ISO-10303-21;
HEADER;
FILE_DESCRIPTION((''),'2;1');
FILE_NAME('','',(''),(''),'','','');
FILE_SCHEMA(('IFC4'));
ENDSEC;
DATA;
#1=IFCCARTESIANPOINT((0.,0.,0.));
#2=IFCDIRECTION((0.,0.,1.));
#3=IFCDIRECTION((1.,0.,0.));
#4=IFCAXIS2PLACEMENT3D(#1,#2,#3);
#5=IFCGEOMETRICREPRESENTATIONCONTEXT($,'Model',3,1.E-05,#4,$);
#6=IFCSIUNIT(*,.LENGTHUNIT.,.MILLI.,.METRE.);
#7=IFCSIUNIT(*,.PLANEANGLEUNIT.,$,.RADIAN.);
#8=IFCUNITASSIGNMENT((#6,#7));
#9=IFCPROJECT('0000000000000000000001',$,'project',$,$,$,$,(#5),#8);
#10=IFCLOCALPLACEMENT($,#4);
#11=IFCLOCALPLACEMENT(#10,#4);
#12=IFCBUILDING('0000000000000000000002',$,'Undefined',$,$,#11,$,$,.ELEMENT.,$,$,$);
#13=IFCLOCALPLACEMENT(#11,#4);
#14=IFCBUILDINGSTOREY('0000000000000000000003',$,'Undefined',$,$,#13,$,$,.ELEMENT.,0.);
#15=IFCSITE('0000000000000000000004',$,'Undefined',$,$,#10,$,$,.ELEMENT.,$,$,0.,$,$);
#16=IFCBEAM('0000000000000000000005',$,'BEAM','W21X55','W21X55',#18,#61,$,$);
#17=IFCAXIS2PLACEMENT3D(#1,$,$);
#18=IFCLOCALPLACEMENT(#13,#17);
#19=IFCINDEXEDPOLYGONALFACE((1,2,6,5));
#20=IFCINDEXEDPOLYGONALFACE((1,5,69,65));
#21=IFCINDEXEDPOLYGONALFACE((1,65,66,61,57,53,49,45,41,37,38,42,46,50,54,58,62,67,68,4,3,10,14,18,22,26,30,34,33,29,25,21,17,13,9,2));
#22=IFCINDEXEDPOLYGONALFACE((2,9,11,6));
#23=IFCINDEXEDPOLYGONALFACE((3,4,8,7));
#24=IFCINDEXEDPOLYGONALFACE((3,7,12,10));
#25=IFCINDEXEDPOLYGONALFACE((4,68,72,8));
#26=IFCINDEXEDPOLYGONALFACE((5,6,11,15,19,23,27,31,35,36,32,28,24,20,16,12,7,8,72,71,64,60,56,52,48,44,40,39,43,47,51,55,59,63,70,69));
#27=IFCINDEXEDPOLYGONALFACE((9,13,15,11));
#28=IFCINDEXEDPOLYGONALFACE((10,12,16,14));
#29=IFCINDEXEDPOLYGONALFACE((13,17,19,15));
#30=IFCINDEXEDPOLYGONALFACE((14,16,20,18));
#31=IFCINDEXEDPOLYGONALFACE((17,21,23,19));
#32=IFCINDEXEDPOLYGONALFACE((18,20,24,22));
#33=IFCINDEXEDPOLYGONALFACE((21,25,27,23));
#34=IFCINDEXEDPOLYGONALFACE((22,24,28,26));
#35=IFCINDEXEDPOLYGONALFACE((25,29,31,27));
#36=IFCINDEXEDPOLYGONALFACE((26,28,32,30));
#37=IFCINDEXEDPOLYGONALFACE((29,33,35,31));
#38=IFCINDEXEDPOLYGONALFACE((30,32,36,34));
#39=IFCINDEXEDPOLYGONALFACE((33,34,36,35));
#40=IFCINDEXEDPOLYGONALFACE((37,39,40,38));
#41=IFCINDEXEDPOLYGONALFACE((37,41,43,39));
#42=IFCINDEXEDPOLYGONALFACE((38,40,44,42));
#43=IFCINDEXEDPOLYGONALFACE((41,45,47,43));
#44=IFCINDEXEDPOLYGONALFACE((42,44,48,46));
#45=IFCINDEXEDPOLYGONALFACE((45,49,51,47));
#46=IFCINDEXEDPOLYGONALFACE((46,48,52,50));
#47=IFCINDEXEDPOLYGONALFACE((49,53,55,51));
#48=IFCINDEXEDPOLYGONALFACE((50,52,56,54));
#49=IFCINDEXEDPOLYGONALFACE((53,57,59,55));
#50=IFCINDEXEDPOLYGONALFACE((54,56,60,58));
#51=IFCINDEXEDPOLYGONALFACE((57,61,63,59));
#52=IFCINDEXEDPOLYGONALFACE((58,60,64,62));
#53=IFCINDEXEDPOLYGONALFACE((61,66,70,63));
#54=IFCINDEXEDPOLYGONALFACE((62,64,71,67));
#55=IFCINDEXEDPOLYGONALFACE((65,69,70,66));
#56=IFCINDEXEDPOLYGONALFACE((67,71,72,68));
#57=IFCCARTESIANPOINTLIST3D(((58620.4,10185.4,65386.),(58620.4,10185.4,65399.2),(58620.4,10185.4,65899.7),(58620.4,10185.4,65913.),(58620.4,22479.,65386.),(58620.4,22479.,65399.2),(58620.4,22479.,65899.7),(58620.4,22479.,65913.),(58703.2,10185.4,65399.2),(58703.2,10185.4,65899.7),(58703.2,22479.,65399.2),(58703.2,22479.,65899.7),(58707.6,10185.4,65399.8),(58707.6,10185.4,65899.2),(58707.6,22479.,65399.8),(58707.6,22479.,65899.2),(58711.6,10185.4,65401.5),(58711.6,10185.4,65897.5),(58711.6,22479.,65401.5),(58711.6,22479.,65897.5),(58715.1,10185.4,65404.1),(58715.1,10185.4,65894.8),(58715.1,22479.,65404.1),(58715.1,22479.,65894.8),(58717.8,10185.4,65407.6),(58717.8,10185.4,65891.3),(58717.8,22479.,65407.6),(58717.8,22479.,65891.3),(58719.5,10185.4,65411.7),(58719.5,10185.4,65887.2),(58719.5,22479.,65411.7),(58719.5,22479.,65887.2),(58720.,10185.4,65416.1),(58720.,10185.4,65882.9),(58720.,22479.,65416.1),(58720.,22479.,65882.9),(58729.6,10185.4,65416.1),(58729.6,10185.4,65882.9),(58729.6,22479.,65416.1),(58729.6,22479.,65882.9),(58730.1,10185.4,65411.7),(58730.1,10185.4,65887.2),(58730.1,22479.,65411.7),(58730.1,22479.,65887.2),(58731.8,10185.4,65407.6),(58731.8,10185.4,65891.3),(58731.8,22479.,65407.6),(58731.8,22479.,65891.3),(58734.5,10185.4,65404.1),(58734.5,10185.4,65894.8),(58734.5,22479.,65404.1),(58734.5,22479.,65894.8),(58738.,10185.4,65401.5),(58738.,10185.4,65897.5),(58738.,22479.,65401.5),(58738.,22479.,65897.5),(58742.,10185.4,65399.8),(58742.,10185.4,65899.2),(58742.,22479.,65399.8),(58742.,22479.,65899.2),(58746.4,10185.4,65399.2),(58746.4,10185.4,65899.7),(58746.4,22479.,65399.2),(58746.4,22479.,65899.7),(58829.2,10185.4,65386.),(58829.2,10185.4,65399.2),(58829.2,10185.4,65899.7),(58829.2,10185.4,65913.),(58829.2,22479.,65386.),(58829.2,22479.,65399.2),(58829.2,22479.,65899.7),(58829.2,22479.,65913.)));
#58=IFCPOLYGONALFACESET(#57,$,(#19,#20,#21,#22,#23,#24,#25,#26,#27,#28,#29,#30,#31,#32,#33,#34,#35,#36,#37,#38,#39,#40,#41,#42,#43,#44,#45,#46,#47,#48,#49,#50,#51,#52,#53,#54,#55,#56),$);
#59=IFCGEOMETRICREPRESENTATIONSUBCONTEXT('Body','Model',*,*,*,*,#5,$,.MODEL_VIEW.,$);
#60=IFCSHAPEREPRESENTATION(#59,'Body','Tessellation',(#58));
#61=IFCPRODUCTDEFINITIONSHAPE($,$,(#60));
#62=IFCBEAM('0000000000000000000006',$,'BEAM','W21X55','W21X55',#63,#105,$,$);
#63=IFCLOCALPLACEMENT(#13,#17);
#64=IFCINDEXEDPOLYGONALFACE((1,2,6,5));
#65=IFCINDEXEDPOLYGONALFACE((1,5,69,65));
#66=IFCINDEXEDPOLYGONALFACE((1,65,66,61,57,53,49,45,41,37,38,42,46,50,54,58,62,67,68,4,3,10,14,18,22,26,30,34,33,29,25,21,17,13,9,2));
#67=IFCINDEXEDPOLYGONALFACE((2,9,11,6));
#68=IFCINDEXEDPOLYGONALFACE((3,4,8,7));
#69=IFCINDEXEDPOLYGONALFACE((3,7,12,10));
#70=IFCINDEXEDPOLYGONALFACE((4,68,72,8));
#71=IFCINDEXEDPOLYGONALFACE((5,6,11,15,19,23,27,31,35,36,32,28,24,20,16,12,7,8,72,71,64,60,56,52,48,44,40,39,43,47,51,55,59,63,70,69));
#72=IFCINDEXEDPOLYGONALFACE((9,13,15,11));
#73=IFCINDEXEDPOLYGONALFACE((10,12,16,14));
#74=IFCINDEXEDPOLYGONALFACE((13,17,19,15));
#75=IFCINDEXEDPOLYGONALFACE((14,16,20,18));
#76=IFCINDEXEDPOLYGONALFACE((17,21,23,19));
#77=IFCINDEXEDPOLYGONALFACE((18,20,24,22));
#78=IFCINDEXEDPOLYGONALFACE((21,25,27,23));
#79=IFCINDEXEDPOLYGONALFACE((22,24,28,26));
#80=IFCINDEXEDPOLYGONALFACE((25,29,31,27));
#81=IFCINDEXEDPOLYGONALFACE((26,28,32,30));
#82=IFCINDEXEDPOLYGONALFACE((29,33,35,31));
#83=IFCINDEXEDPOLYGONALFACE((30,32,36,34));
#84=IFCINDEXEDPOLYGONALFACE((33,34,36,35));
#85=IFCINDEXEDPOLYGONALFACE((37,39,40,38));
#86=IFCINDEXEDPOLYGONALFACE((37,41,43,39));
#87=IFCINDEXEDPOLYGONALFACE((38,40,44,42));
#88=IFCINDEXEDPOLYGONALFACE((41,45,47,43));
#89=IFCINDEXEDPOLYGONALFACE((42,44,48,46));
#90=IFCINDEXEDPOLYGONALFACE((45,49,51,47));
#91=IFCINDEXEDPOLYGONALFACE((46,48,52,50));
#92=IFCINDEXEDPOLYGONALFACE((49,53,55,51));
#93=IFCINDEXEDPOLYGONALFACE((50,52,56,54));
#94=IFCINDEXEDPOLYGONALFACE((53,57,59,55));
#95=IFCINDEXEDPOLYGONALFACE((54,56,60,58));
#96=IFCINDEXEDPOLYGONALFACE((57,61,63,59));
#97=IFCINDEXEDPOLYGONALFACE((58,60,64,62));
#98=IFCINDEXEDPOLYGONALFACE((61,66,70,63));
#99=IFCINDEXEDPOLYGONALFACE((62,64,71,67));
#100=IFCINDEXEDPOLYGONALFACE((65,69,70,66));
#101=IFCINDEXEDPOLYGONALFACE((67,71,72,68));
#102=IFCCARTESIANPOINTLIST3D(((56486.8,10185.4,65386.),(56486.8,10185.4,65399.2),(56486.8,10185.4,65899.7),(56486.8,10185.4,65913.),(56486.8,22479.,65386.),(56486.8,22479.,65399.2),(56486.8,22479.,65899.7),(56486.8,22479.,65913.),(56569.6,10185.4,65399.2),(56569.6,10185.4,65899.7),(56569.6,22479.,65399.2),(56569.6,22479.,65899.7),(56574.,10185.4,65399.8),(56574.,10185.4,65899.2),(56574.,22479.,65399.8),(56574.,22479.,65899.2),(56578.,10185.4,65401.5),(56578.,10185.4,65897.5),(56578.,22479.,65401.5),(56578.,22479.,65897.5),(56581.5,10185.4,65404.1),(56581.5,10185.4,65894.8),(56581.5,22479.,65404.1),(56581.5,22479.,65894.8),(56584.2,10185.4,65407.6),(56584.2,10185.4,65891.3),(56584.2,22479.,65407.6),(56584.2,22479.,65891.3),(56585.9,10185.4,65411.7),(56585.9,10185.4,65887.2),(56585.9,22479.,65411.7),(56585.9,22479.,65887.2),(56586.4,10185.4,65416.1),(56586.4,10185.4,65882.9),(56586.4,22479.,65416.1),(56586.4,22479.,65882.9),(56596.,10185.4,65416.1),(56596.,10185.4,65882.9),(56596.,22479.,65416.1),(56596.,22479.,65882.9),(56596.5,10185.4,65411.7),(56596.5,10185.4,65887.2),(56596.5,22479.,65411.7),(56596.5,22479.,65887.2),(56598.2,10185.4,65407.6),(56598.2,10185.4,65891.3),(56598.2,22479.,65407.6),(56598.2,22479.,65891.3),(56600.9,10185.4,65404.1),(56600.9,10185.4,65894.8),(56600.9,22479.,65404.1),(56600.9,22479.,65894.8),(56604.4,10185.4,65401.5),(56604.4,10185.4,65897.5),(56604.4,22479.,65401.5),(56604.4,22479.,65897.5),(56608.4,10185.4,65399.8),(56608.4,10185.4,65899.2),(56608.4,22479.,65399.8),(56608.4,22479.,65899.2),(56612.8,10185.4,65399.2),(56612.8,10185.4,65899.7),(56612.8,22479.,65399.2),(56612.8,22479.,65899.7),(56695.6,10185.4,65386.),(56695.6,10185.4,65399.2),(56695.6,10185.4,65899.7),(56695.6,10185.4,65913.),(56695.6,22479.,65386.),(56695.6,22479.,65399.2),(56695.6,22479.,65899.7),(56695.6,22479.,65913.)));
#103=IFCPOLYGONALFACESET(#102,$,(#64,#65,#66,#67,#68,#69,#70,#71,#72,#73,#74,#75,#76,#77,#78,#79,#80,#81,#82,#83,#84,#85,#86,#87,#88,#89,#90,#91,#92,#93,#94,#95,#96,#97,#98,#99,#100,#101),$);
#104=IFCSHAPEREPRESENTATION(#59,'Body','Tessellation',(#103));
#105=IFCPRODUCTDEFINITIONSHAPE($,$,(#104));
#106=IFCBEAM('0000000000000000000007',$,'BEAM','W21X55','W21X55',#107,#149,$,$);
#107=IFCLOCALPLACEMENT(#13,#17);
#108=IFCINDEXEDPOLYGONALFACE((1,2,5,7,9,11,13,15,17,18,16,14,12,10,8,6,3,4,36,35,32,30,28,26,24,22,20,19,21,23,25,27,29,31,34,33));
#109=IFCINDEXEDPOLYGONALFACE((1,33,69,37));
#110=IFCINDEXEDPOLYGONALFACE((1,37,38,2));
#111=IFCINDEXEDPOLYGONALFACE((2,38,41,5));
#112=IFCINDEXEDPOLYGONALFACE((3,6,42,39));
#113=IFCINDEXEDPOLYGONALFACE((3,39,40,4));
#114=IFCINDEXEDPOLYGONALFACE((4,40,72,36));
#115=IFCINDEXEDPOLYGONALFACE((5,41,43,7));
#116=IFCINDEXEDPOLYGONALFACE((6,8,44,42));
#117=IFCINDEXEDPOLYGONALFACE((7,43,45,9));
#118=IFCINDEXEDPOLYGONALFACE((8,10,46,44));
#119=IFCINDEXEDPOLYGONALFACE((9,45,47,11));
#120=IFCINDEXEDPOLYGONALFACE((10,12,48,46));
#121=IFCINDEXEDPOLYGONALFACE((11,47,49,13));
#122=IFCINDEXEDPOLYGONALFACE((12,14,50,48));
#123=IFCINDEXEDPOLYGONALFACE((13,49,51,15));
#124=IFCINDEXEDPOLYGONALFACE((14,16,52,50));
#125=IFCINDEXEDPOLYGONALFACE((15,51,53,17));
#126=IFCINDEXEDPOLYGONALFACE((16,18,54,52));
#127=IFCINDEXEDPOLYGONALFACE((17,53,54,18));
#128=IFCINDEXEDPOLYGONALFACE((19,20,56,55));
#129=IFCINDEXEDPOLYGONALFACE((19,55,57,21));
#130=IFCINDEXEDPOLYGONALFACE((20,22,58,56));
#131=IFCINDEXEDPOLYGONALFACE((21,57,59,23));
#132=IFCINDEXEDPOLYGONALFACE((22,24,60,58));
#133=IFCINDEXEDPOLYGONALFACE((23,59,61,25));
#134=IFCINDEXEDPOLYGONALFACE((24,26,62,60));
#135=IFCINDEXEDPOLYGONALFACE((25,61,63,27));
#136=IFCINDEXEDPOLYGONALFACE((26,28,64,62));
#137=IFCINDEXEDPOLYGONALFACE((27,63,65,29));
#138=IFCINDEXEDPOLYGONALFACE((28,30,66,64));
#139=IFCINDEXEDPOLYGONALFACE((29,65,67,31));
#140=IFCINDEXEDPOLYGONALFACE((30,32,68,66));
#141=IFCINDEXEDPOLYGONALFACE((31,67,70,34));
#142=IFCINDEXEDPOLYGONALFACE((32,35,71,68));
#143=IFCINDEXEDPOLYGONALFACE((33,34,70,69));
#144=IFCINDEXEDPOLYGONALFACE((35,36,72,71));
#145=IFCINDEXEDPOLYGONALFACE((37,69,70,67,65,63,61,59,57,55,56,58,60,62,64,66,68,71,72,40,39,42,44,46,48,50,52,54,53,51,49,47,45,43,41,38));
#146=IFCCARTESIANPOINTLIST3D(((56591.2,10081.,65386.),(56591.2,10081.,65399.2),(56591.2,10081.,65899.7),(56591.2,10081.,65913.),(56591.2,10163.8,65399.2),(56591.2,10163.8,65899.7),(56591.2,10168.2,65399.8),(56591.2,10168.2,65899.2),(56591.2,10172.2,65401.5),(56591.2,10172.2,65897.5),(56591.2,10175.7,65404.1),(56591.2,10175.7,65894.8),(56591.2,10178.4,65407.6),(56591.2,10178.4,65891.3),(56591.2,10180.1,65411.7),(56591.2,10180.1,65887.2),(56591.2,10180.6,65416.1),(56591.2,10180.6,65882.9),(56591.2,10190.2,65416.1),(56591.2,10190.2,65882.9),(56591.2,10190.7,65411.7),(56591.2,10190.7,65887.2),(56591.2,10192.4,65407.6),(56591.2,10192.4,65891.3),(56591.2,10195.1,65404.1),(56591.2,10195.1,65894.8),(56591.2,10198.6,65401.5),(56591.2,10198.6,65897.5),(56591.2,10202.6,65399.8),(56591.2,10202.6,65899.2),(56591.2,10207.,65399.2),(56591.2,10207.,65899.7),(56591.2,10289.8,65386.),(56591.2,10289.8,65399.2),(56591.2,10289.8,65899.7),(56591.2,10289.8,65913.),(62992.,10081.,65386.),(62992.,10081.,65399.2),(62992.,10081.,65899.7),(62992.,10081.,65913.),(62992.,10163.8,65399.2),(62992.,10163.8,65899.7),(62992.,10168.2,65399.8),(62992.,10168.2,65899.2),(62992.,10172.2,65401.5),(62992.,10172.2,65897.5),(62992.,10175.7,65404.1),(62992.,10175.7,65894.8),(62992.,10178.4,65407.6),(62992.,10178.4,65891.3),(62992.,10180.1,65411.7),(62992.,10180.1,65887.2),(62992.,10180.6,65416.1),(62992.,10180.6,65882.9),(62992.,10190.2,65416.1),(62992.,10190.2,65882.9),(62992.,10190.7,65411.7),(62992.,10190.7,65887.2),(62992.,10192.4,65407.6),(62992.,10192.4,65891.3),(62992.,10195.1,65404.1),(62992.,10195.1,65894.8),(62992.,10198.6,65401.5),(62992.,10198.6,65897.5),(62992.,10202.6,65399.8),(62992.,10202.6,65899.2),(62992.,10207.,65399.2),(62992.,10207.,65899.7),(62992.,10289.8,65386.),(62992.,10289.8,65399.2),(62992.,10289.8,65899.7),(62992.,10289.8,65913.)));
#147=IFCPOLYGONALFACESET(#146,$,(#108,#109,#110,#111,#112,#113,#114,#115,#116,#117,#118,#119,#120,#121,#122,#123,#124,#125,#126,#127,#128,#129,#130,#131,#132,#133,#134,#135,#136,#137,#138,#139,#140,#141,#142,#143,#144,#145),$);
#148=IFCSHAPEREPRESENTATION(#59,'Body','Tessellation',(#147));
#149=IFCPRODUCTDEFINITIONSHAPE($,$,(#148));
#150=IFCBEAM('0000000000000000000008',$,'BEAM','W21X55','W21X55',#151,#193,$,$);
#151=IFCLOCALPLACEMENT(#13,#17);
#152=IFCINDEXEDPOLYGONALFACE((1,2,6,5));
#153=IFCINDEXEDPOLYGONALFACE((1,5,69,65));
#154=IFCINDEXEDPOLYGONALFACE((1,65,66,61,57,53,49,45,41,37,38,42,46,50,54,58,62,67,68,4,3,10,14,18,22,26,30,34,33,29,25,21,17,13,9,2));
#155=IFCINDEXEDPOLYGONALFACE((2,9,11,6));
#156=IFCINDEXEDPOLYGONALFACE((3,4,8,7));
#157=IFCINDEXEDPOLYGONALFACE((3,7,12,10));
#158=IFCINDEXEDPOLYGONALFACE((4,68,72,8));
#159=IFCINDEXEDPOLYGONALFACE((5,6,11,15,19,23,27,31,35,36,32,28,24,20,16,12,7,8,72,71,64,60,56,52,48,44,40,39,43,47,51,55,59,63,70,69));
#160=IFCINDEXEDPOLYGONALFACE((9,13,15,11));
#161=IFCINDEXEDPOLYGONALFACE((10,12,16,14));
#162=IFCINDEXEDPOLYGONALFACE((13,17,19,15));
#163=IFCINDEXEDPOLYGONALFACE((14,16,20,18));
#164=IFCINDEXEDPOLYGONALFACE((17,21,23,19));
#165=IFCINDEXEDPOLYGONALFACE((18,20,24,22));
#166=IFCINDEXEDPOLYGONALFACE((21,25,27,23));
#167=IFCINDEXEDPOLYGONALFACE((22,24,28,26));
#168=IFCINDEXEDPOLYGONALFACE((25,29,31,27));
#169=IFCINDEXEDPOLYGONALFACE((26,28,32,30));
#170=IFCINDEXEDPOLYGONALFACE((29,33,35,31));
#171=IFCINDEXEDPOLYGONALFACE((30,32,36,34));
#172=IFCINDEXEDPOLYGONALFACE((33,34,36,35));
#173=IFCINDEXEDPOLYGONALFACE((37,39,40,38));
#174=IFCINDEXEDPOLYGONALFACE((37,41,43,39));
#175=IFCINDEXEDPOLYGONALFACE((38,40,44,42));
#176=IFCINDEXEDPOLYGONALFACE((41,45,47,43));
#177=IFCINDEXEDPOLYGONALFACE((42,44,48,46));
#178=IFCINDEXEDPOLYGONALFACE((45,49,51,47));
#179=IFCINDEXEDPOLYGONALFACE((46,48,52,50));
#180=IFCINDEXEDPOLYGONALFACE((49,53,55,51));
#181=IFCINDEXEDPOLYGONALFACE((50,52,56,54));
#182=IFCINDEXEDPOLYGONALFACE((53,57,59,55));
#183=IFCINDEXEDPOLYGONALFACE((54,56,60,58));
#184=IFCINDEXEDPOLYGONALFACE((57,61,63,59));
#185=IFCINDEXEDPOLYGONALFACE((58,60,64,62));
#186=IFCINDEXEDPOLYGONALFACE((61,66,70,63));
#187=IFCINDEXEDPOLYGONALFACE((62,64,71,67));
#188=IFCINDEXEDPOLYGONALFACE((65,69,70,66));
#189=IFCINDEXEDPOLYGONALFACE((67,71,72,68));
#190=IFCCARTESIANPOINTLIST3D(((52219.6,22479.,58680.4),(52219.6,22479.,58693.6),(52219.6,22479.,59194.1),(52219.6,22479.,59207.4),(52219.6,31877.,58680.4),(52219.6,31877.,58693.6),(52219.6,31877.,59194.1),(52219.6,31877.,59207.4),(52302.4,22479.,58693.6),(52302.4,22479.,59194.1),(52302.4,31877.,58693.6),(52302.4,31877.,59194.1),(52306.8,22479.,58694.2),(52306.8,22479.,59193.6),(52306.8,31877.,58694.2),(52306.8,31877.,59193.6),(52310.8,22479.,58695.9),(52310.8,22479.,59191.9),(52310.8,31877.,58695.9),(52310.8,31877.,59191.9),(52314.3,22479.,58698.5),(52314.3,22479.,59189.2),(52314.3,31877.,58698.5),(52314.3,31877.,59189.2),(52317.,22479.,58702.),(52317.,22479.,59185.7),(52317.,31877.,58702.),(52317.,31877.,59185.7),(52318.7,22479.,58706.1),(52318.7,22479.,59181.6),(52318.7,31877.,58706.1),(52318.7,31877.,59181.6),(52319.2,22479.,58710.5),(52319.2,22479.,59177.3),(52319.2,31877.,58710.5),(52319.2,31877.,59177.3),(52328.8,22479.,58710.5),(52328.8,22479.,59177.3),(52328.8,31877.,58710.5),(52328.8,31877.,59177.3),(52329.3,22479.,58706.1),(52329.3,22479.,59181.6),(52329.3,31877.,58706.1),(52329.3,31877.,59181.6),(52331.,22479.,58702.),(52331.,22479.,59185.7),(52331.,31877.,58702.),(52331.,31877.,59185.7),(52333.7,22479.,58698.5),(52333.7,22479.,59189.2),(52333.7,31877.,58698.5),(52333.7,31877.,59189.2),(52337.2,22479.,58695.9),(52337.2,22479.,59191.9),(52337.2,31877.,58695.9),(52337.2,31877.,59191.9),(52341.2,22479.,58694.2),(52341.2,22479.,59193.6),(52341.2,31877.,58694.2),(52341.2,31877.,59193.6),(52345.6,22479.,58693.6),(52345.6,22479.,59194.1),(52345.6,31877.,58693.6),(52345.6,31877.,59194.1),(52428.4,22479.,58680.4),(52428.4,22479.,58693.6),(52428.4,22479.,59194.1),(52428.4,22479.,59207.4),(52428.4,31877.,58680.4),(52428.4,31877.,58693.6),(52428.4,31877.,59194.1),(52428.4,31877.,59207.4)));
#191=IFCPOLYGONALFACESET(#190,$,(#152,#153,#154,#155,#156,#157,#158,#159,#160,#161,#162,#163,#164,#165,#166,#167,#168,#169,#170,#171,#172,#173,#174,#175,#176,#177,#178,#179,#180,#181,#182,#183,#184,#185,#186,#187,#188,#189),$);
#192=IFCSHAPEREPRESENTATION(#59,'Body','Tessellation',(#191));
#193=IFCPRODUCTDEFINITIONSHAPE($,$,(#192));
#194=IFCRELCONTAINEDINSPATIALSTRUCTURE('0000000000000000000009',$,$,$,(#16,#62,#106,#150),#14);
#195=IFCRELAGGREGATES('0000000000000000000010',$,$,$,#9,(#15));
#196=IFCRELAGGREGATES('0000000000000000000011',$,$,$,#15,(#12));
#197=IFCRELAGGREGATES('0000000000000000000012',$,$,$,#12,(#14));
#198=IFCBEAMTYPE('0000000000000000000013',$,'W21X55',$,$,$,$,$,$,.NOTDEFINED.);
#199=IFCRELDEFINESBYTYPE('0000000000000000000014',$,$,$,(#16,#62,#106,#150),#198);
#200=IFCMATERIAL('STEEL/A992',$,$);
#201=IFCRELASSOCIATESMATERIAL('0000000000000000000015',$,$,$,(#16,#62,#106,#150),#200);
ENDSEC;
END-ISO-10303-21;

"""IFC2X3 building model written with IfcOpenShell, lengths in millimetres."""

from ifc_helpers import new_model, si_unit, frame, origin_with_axes, origin_2d_with_axis, place, context, subcontext, project, spatial, i_section, extrude, material, type_object, element, save


model = new_model("IFC2X3")

# Units and contexts
model_context = context("Model", 3, precision=1e-05, world=origin_with_axes())
body_context = subcontext(model_context, "Body", "Model", "MODEL_VIEW")
ifc_project = project(units=[si_unit("LENGTHUNIT", "METRE", prefix="MILLI"), si_unit("PLANEANGLEUNIT", "RADIAN")], contexts=[model_context])

# Site, building, storey
site_placement = place(None, origin_with_axes())
site = spatial("IfcSite", under=ifc_project, at=site_placement, Name="Undefined", CompositionType="ELEMENT", RefElevation=0.0)
building_placement = place(site_placement, origin_with_axes())
building = spatial("IfcBuilding", under=site, at=building_placement, Name="Undefined", CompositionType="ELEMENT")
storey_placement = place(building_placement, origin_with_axes())
storey = spatial("IfcBuildingStorey", under=building, at=storey_placement, Name="Undefined", CompositionType="ELEMENT", Elevation=0.0)

# Shared definitions
ifc_material_1 = material(Name="STEEL/A992")

# Beams
beam_type_1 = type_object("IfcBeamType", Name="W21X55", PredefinedType="NOTDEFINED")
for number, where, z_axis, x_axis, name in (
    (1, (58724.8, 10185.4, 65649.5), (0.0, 0.0, 1.0), (0.0, 1.0, 0.0), "BEAM"),
    (2, (56591.2, 10185.4, 65649.5), (0.0, 0.0, 1.0), (0.0, 1.0, 0.0), "BEAM"),
):
    element("IfcBeam", number, at=place(storey_placement, frame(where, z_axis=z_axis, x_axis=x_axis)), inside=storey, type_object=beam_type_1, material=ifc_material_1, Name=name, Description="W21X55", ObjectType="W21X55", context=body_context, shape_type="SweptSolid", body=[
        extrude(i_section(OverallWidth=208.8, OverallDepth=527.0, WebThickness=9.5, FlangeThickness=13.3, FilletRadius=16.9, at=origin_2d_with_axis()), frame((12293.6, 0.0, 0.0), z_axis=(-1.0, 0.0, 0.0), x_axis=(0.0, -1.0, 0.0)), (0.0, 0.0, 1.0), 12293.6),
    ])
beam_1_placement = place(storey_placement, frame((56591.2, 10185.4, 65649.5), z_axis=(0.0, 0.0, 1.0), x_axis=(1.0, 0.0, 0.0)))
element("IfcBeam", 3, at=beam_1_placement, inside=storey, type_object=beam_type_1, material=ifc_material_1, Name="BEAM", Description="W21X55", ObjectType="W21X55", context=body_context, shape_type="SweptSolid", body=[
    extrude(i_section(OverallWidth=208.8, OverallDepth=527.0, WebThickness=9.5, FlangeThickness=13.3, FilletRadius=16.9, at=origin_2d_with_axis()), frame((6400.8, 0.0, 0.0), z_axis=(-1.0, 0.0, 0.0), x_axis=(0.0, -1.0, 0.0)), (0.0, 0.0, 1.0), 6400.8),
])
for number, where, z_axis, x_axis, name in (
    (4, (52324.0, 22479.0, 58943.9), (0.0, 0.0, 1.0), (0.0, 1.0, 0.0), "BEAM"),
):
    element("IfcBeam", number, at=place(storey_placement, frame(where, z_axis=z_axis, x_axis=x_axis)), inside=storey, type_object=beam_type_1, material=ifc_material_1, Name=name, Description="W21X55", ObjectType="W21X55", context=body_context, shape_type="SweptSolid", body=[
        extrude(i_section(OverallWidth=208.8, OverallDepth=527.0, WebThickness=9.5, FlangeThickness=13.3, FilletRadius=16.9, at=origin_2d_with_axis()), frame((9398.0, 0.0, 0.0), z_axis=(-1.0, 0.0, 0.0), x_axis=(0.0, -1.0, 0.0)), (0.0, 0.0, 1.0), 9398.0),
    ])

save(model, "model.ifc")
